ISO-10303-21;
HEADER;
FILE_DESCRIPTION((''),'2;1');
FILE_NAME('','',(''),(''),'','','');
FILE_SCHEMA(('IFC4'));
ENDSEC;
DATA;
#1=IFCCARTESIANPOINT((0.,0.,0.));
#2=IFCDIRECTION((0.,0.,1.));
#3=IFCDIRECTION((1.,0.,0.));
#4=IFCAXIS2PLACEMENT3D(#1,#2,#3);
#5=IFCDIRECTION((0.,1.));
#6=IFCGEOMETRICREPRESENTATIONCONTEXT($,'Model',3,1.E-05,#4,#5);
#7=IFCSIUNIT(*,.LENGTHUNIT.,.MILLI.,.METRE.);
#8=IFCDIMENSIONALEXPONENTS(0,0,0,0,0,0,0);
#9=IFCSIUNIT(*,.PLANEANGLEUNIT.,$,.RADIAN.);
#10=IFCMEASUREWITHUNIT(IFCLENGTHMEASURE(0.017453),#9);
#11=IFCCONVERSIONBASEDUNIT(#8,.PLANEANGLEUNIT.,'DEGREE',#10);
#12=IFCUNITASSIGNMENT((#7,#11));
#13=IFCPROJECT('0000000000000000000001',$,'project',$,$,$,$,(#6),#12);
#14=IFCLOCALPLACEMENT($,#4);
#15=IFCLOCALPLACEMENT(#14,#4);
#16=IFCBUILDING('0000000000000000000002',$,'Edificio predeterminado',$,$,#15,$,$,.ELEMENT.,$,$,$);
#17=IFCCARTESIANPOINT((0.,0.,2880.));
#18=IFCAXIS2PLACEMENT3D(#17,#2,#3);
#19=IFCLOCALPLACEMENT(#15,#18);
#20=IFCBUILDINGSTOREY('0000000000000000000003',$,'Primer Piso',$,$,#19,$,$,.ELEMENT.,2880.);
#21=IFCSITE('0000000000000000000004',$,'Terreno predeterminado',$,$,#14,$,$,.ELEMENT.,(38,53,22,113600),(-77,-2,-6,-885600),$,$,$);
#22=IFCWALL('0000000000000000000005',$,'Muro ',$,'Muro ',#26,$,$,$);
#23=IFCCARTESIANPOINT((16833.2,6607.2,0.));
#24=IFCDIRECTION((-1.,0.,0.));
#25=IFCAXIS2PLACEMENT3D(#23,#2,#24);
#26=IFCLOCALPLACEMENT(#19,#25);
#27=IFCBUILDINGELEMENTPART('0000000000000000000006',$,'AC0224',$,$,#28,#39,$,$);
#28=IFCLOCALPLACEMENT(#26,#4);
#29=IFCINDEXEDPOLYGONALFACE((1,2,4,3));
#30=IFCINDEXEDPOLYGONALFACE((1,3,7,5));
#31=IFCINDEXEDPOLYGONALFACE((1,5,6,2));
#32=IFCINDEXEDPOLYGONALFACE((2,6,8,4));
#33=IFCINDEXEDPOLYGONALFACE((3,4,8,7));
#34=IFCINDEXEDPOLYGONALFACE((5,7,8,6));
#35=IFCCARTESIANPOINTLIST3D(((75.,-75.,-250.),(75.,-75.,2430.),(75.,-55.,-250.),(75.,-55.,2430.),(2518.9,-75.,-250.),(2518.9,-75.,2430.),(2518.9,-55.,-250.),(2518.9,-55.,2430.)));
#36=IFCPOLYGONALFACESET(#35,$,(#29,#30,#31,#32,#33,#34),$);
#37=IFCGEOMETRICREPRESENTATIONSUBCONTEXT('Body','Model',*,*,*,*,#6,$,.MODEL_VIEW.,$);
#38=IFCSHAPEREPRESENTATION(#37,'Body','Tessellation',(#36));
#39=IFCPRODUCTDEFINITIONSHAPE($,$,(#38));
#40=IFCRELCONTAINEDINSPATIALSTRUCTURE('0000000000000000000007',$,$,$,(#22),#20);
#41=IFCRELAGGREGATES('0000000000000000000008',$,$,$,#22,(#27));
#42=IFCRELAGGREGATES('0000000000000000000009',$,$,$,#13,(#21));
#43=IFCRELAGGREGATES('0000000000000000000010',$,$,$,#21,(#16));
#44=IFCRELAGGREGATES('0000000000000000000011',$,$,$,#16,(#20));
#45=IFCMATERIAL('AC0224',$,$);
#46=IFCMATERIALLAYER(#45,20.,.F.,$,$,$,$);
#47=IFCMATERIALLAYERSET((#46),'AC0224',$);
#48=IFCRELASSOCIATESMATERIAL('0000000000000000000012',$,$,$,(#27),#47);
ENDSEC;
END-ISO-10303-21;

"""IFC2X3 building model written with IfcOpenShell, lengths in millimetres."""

from ifc_helpers import new_model, entity, si_unit, converted_unit, direction, frame, origin_with_axes, place, context, subcontext, project, spatial, polyline, outline, extrude, material, layer, layer_set, layer_usage, element, aggregate, save


model = new_model("IFC2X3")

# Units and contexts
model_context = context("Model", 3, precision=1e-05, world=origin_with_axes(), true_north=direction((0.0, 1.0)))
body_context = subcontext(model_context, "Body", "Model", "MODEL_VIEW")
ifc_project = project(units=[si_unit("LENGTHUNIT", "METRE", prefix="MILLI"), converted_unit("PLANEANGLEUNIT", "DEGREE", entity("IfcLengthMeasure", 0.017453), si_unit("PLANEANGLEUNIT", "RADIAN"), dimensions=[0, 0, 0, 0, 0, 0, 0])], contexts=[model_context])

# Site, building, storey
site_placement = place(None, origin_with_axes())
site = spatial("IfcSite", under=ifc_project, at=site_placement, Name="Terreno predeterminado", CompositionType="ELEMENT", RefLatitude=(38, 53, 22, 113600), RefLongitude=(-77, -2, -6, -885600))
building_placement = place(site_placement, origin_with_axes())
building = spatial("IfcBuilding", under=site, at=building_placement, Name="Edificio predeterminado", CompositionType="ELEMENT")
storey_placement = place(building_placement, frame((0.0, 0.0, 2880.0), z_axis=(0.0, 0.0, 1.0), x_axis=(1.0, 0.0, 0.0)))
storey = spatial("IfcBuildingStorey", under=building, at=storey_placement, Name="Primer Piso", CompositionType="ELEMENT", Elevation=2880.0)

# Wall, building element part
wall_1_placement = place(storey_placement, frame((16833.2, 6607.2, 0.0), z_axis=(0.0, 0.0, 1.0), x_axis=(-1.0, 0.0, 0.0)))
wall_1 = element("IfcWall", 1, at=wall_1_placement, inside=storey, Name="Muro ", ObjectType="Muro ")
ifc_material_1 = material(Name="AC0224")
ifc_layer_1 = layer(ifc_material_1, 20.0, ventilated=False)
ifc_layer_set_1 = layer_set([ifc_layer_1], Name="AC0224")
ifc_layer_usage_1 = layer_usage(ifc_layer_set_1, "AXIS2", "NEGATIVE", 55.0)
building_element_part_1_placement = place(wall_1_placement, origin_with_axes())
building_element_part_1 = element("IfcBuildingElementPart", 2, at=building_element_part_1_placement, material=ifc_layer_usage_1, Name="AC0224", context=body_context, shape_type="SweptSolid", body=[
    extrude(outline(polyline([(2518.9, -55.0), (2518.9, -75.0), (75.0, -75.0), (75.0, -55.0), (2518.9, -55.0)])), frame((0.0, 0.0, -250.0), z_axis=(0.0, 0.0, 1.0), x_axis=(1.0, 0.0, 0.0)), (0.0, 0.0, 1.0), 2680.0),
])
aggregate(wall_1, [building_element_part_1])

save(model, "model.ifc")
